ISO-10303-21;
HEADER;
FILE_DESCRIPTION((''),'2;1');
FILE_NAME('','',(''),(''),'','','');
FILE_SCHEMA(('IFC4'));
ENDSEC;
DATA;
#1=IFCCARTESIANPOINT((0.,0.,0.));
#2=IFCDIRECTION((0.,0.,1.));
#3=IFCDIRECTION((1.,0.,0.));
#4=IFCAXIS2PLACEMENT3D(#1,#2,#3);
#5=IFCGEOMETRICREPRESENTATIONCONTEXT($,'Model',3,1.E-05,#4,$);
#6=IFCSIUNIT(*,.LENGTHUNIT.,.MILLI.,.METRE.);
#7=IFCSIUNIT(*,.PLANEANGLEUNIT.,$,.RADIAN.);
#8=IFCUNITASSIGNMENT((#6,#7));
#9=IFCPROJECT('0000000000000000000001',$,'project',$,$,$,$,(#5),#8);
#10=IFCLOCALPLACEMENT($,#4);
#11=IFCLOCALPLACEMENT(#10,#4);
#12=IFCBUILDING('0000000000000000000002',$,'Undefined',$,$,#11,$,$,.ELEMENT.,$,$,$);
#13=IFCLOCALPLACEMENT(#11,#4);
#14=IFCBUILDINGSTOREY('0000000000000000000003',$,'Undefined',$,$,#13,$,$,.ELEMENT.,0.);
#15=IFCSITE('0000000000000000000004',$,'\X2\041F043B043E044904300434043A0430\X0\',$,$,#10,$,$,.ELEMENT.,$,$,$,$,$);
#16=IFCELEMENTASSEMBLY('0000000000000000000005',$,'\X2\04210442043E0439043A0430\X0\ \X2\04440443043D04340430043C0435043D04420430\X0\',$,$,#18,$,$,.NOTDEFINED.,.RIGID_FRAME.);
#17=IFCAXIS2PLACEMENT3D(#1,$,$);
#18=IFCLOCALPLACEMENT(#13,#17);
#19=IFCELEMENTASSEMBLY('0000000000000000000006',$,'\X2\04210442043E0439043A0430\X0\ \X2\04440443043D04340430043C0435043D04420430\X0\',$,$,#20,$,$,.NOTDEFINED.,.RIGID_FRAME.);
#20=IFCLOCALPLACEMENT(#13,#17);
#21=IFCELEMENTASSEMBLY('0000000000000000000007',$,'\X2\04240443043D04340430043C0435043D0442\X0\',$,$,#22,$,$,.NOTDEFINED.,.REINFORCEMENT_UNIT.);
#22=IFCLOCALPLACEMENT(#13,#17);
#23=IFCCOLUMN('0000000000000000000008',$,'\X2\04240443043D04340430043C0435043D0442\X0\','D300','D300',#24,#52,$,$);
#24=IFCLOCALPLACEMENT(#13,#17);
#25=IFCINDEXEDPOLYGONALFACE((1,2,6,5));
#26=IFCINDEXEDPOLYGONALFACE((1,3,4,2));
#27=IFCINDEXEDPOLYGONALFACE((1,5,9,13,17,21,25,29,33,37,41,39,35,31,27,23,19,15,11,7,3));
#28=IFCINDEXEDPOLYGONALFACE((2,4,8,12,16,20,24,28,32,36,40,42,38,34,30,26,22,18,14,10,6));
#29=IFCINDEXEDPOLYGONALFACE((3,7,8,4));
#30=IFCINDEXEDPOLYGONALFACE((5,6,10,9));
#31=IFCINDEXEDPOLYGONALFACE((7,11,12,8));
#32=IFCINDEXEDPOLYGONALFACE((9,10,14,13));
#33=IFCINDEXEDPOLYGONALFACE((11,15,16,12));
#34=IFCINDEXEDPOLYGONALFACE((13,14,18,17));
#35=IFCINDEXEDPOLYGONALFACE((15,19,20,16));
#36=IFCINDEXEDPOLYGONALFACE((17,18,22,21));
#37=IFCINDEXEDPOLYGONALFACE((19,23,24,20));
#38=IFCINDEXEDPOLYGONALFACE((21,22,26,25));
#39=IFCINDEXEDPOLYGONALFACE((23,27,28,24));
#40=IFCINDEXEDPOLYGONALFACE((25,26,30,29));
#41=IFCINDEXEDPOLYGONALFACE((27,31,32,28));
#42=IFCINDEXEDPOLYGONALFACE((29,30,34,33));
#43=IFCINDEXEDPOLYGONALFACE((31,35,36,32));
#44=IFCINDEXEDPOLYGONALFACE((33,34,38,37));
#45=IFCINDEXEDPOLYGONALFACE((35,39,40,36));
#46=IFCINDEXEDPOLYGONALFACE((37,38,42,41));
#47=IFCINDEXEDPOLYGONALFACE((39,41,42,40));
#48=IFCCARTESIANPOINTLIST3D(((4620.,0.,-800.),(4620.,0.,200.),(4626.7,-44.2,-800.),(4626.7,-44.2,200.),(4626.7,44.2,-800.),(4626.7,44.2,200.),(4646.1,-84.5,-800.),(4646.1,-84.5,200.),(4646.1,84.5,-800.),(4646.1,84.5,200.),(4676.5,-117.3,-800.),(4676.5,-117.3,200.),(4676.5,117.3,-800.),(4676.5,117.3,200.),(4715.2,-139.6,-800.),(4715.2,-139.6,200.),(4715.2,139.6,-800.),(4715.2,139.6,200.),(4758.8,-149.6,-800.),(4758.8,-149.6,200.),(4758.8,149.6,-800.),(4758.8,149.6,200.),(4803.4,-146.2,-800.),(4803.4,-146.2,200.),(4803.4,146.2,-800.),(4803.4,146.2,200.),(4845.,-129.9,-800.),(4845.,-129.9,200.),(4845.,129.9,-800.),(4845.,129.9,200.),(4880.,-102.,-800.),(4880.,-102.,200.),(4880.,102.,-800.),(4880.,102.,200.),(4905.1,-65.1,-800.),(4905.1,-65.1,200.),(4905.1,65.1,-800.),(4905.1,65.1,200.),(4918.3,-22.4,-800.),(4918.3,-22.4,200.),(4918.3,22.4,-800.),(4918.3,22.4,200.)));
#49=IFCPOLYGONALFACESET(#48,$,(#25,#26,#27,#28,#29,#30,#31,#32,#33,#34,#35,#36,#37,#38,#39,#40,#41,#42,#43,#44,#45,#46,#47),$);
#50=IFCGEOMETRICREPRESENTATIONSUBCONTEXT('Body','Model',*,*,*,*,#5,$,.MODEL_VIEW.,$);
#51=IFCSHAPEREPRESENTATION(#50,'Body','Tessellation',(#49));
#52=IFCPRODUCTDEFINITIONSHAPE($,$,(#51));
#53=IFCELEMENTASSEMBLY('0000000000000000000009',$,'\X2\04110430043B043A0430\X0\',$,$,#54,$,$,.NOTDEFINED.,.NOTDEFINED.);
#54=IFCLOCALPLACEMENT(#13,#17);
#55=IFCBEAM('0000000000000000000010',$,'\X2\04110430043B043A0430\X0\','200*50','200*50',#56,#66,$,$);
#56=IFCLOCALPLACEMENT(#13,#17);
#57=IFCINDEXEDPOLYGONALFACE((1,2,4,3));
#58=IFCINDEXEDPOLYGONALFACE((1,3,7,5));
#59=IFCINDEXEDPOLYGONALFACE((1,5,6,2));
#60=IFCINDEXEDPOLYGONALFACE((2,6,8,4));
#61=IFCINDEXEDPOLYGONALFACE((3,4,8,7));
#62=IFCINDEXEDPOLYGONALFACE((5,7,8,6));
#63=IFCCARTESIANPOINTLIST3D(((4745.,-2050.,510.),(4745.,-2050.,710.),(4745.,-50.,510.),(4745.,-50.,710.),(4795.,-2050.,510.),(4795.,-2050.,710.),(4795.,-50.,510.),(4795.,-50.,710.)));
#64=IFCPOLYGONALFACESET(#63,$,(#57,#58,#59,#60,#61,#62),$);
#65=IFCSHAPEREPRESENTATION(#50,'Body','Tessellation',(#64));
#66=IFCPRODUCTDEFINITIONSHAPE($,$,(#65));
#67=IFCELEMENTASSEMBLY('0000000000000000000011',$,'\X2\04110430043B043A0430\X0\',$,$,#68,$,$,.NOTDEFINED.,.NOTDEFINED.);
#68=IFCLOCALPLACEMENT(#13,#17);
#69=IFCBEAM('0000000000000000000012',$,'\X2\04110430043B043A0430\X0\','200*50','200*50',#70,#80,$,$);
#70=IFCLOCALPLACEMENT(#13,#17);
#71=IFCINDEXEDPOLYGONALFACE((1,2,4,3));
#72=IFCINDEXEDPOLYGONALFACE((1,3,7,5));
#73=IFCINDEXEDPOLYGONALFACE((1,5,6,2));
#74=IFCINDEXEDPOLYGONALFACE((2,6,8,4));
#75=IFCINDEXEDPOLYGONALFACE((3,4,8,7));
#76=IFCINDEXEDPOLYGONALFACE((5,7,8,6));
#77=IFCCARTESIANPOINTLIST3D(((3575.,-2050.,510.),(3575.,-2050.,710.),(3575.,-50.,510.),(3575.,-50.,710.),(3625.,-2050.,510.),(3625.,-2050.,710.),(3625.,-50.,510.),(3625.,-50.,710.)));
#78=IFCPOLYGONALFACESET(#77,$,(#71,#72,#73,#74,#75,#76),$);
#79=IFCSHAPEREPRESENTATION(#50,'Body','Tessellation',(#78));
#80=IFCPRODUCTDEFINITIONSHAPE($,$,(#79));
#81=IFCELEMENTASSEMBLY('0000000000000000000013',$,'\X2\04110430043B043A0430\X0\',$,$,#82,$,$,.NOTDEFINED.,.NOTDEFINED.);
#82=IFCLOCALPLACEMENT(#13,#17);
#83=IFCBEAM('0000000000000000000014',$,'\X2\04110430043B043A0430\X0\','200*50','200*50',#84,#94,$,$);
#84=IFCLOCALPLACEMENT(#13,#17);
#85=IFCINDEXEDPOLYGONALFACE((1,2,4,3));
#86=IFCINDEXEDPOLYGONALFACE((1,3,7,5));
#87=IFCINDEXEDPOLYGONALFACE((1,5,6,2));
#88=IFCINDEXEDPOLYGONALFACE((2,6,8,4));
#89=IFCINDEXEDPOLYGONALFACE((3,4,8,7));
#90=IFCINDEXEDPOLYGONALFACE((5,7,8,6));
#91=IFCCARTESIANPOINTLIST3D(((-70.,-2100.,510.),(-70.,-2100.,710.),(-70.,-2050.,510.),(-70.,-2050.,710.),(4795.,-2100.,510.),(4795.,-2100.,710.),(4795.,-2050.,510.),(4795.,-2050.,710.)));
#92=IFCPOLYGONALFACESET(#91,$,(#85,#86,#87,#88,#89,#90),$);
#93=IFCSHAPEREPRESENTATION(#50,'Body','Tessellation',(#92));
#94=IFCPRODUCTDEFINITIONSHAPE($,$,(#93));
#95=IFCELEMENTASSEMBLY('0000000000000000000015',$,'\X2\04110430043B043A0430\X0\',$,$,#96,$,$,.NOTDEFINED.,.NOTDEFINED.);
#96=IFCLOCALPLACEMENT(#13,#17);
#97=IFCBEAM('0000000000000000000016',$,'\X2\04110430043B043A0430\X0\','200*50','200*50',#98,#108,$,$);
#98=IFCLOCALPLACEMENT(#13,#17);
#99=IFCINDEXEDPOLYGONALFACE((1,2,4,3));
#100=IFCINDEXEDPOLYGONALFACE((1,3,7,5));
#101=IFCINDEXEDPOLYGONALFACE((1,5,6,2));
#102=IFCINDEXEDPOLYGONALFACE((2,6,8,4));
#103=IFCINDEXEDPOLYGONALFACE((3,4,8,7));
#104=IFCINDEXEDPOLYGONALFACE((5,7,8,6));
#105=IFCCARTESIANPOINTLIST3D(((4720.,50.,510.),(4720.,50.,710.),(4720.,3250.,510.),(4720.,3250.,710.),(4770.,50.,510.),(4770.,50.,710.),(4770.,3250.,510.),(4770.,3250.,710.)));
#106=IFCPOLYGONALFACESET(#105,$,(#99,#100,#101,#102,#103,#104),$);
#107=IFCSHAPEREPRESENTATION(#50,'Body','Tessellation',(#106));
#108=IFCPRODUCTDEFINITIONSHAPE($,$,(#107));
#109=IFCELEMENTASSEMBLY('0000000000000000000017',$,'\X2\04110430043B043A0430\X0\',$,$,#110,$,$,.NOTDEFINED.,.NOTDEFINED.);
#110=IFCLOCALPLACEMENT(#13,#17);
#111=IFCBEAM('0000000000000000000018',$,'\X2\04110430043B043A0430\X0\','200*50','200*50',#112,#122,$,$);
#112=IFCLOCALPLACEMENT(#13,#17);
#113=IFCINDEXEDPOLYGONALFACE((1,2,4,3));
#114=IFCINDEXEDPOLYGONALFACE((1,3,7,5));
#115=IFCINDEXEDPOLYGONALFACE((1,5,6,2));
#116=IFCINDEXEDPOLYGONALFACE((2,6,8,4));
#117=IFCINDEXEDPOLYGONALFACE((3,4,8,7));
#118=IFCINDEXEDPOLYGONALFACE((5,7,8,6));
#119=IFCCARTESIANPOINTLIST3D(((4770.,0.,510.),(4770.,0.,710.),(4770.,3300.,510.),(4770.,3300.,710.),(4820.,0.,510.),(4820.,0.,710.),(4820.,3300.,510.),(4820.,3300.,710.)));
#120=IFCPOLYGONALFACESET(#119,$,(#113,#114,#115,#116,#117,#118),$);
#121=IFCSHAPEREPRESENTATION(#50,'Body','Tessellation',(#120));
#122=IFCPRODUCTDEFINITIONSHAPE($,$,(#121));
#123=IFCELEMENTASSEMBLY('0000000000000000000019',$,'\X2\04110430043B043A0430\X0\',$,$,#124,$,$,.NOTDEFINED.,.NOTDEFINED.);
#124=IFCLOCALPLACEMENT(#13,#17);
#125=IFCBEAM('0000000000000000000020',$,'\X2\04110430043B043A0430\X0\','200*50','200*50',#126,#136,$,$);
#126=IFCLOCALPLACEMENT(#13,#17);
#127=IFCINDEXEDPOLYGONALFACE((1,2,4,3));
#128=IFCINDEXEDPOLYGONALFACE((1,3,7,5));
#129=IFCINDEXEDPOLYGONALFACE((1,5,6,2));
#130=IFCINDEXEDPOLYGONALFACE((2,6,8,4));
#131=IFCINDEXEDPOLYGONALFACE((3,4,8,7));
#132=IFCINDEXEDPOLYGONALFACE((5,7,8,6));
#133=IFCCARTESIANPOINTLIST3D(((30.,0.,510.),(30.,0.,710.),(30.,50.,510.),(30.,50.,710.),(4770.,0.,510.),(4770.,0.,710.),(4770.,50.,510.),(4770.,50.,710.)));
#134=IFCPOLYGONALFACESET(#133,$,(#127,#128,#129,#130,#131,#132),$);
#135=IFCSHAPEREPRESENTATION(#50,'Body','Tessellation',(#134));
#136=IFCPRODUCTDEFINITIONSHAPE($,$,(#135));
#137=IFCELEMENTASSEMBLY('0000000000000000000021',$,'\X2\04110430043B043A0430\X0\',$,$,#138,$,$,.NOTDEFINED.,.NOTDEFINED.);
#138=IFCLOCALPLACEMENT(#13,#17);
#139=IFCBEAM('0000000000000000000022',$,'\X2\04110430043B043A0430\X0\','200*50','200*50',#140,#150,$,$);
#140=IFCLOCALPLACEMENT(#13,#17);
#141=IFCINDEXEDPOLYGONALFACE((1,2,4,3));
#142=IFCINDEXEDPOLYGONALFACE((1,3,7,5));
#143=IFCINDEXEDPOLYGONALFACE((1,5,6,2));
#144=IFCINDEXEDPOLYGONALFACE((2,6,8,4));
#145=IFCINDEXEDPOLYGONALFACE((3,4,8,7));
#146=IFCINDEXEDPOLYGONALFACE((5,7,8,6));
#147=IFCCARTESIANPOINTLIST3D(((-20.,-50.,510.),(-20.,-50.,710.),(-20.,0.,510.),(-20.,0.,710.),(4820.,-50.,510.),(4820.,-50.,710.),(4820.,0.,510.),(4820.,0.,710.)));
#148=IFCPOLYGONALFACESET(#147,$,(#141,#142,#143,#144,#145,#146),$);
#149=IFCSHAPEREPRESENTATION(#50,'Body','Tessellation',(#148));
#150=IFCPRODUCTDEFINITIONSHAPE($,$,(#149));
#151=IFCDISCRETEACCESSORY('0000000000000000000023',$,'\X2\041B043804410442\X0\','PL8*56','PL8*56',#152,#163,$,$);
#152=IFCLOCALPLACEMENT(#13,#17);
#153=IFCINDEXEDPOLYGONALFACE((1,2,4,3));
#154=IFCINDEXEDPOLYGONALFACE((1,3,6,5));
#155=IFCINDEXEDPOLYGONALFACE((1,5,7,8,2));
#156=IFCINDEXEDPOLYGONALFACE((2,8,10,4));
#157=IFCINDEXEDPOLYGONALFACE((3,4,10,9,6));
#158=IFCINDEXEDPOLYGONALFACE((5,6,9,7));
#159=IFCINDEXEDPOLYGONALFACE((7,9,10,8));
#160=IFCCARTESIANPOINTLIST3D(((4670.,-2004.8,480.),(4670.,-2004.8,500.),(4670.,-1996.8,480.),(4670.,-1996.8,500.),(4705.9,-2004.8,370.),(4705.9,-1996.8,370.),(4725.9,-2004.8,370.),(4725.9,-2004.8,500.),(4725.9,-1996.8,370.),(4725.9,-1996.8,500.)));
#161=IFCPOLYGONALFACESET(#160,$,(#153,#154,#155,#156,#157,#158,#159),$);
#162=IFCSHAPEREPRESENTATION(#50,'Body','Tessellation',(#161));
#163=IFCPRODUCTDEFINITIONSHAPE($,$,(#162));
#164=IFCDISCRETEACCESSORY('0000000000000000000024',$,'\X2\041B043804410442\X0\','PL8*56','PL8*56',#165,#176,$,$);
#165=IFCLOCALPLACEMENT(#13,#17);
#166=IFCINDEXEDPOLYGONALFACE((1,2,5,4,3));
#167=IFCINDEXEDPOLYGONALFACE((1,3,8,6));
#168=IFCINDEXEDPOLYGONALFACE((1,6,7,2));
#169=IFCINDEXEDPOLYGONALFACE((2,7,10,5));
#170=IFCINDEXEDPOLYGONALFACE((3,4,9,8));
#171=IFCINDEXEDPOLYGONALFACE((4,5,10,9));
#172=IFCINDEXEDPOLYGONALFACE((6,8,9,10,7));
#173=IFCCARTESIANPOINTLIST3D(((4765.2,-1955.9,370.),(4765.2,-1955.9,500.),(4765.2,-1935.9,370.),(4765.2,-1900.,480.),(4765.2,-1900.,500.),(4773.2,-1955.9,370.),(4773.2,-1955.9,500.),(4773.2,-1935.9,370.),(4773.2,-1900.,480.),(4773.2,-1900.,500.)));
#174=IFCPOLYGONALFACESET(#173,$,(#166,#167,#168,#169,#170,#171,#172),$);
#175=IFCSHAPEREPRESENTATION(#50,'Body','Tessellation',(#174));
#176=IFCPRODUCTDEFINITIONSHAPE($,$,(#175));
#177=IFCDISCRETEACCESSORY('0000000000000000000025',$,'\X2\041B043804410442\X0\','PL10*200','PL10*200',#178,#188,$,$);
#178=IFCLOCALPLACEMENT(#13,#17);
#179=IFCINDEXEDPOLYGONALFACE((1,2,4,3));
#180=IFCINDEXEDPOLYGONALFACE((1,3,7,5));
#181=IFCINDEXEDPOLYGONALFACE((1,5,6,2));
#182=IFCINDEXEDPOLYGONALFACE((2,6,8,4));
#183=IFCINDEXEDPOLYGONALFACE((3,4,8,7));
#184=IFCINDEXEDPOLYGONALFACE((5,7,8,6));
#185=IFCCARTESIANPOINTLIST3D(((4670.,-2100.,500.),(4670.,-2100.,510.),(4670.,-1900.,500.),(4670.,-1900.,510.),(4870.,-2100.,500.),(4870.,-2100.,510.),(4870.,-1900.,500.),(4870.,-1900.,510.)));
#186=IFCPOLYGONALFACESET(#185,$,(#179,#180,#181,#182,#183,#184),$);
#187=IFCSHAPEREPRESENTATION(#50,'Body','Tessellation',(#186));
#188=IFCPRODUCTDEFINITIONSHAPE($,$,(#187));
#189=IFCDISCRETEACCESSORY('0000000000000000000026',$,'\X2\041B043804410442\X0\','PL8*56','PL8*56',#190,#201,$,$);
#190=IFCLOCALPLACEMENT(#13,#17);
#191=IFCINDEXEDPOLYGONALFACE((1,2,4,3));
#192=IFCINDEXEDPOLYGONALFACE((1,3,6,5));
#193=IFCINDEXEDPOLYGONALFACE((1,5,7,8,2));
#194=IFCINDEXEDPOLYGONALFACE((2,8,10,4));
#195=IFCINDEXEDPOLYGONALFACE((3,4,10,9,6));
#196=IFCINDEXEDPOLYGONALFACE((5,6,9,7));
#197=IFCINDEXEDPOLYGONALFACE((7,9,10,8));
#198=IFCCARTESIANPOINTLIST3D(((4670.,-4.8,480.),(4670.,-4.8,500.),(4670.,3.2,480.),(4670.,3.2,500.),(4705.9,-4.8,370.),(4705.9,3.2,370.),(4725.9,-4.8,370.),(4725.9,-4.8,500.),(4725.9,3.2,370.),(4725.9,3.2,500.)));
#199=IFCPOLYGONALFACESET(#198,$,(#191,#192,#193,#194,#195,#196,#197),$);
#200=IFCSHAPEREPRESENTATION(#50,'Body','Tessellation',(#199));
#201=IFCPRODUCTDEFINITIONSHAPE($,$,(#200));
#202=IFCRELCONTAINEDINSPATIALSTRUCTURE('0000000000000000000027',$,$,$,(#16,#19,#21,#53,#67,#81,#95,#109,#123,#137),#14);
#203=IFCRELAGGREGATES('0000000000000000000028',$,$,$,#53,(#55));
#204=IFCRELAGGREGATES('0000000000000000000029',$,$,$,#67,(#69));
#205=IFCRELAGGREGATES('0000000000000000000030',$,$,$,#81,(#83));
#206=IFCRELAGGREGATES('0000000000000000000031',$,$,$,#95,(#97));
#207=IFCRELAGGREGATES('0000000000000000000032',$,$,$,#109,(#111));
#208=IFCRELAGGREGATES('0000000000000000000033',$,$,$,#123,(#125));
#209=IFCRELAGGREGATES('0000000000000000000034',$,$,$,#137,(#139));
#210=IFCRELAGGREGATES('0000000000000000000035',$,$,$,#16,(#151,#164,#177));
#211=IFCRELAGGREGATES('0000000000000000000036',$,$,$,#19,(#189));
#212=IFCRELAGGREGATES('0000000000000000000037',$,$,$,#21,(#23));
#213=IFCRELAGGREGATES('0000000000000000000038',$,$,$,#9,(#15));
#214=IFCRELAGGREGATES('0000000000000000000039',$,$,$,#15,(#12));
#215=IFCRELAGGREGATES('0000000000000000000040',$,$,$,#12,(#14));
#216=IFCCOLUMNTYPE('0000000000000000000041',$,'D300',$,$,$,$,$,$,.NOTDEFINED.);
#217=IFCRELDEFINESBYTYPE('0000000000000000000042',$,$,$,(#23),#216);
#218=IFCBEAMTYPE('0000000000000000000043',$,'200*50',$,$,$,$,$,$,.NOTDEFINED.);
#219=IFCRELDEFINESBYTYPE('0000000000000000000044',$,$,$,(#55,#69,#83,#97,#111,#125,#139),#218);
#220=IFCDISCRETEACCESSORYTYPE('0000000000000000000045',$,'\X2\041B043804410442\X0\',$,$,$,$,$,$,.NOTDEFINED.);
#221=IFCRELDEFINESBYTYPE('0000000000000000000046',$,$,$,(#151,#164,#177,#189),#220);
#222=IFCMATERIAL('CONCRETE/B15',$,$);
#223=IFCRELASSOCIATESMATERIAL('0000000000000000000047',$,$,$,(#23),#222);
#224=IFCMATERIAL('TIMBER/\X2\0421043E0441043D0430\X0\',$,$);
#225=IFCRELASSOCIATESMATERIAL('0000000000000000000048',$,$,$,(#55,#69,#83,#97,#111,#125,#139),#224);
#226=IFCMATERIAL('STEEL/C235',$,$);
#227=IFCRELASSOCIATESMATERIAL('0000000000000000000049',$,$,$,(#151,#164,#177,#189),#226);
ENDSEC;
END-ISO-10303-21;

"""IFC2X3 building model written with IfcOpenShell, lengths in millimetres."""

from ifc_helpers import new_model, si_unit, frame, origin_with_axes, origin_2d_with_axis, place, context, subcontext, project, spatial, polyline, rectangle, circle, outline, extrude, material, type_object, element, aggregate, save


model = new_model("IFC2X3")

# Units and contexts
model_context = context("Model", 3, precision=1e-05, world=origin_with_axes())
body_context = subcontext(model_context, "Body", "Model", "MODEL_VIEW")
ifc_project = project(units=[si_unit("LENGTHUNIT", "METRE", prefix="MILLI"), si_unit("PLANEANGLEUNIT", "RADIAN")], contexts=[model_context])

# Site, building, storey
site_placement = place(None, origin_with_axes())
site = spatial("IfcSite", under=ifc_project, at=site_placement, Name="Площадка", CompositionType="ELEMENT")
building_placement = place(site_placement, origin_with_axes())
building = spatial("IfcBuilding", under=site, at=building_placement, Name="Undefined", CompositionType="ELEMENT")
storey_placement = place(building_placement, origin_with_axes())
storey = spatial("IfcBuildingStorey", under=building, at=storey_placement, Name="Undefined", CompositionType="ELEMENT", Elevation=0.0)

# Element assemblies, column
assembly_1_placement = place(storey_placement, origin_with_axes())
assembly_1 = element("IfcElementAssembly", 1, at=assembly_1_placement, inside=storey, Name="Стойка фундамента", AssemblyPlace="NOTDEFINED", PredefinedType="RIGID_FRAME")
ifc_material_1 = material(Name="STEEL/C235")
assembly_2_placement = place(storey_placement, origin_with_axes())
assembly_2 = element("IfcElementAssembly", 2, at=assembly_2_placement, inside=storey, Name="Стойка фундамента", AssemblyPlace="NOTDEFINED", PredefinedType="RIGID_FRAME")
ifc_material_2 = material(Name="CONCRETE/B15")
column_type_1 = type_object("IfcColumnType", Name="D300", PredefinedType="NOTDEFINED")
assembly_3_placement = place(storey_placement, origin_with_axes())
assembly_3 = element("IfcElementAssembly", 3, at=assembly_3_placement, inside=storey, Name="Фундамент", AssemblyPlace="NOTDEFINED", PredefinedType="REINFORCEMENT_UNIT")
column_1_placement = place(assembly_3_placement, frame((4770.0, 0.0, -800.0), z_axis=(0.0, 0.0, 1.0), x_axis=(0.0, 1.0, 0.0)))
column_1 = element("IfcColumn", 4, at=column_1_placement, type_object=column_type_1, material=ifc_material_2, Name="Фундамент", Description="D300", ObjectType="D300", context=body_context, shape_type="SweptSolid", body=[
    extrude(circle(Radius=150.0, at=origin_2d_with_axis()), frame((0.0, 0.0, 1000.0), z_axis=(0.0, 0.0, -1.0), x_axis=(0.0, 1.0, 0.0)), (0.0, 0.0, 1.0), 1000.0),
])

# Element assemblies, beams
assembly_4_placement = place(storey_placement, origin_with_axes())
assembly_4 = element("IfcElementAssembly", 5, at=assembly_4_placement, inside=storey, Name="Балка", AssemblyPlace="NOTDEFINED", PredefinedType="NOTDEFINED")
ifc_material_3 = material(Name="TIMBER/Сосна")
beam_type = type_object("IfcBeamType", Name="200*50", PredefinedType="NOTDEFINED")
beam_1_placement = place(assembly_4_placement, frame((4770.0, -2050.0, 610.0), z_axis=(0.0, 0.0, -1.0), x_axis=(0.0, 1.0, 0.0)))
beam_1 = element("IfcBeam", 6, at=beam_1_placement, type_object=beam_type, material=ifc_material_3, Name="Балка", Description="200*50", ObjectType="200*50", context=body_context, shape_type="SweptSolid", body=[
    extrude(rectangle(XDim=50.0, YDim=200.0, at=origin_2d_with_axis()), frame((2000.0, 0.0, 0.0), z_axis=(-1.0, 0.0, 0.0), x_axis=(0.0, -1.0, 0.0)), (0.0, 0.0, 1.0), 2000.0),
])
aggregate(assembly_4, [beam_1])
assembly_5_placement = place(storey_placement, origin_with_axes())
assembly_5 = element("IfcElementAssembly", 7, at=assembly_5_placement, inside=storey, Name="Балка", AssemblyPlace="NOTDEFINED", PredefinedType="NOTDEFINED")
beam_2_placement = place(assembly_5_placement, frame((3600.0, -2050.0, 610.0), z_axis=(0.0, 0.0, -1.0), x_axis=(0.0, 1.0, 0.0)))
beam_2 = element("IfcBeam", 8, at=beam_2_placement, type_object=beam_type, material=ifc_material_3, Name="Балка", Description="200*50", ObjectType="200*50", context=body_context, shape_type="SweptSolid", body=[
    extrude(rectangle(XDim=50.0, YDim=200.0, at=origin_2d_with_axis()), frame((2000.0, 0.0, 0.0), z_axis=(-1.0, 0.0, 0.0), x_axis=(0.0, -1.0, 0.0)), (0.0, 0.0, 1.0), 2000.0),
])
aggregate(assembly_5, [beam_2])
assembly_6_placement = place(storey_placement, origin_with_axes())
assembly_6 = element("IfcElementAssembly", 9, at=assembly_6_placement, inside=storey, Name="Балка", AssemblyPlace="NOTDEFINED", PredefinedType="NOTDEFINED")
beam_3_placement = place(assembly_6_placement, frame((4795.0, -2075.0, 610.0), z_axis=(0.0, 0.0, -1.0), x_axis=(-1.0, 0.0, 0.0)))
beam_3 = element("IfcBeam", 10, at=beam_3_placement, type_object=beam_type, material=ifc_material_3, Name="Балка", Description="200*50", ObjectType="200*50", context=body_context, shape_type="SweptSolid", body=[
    extrude(rectangle(XDim=50.0, YDim=200.0, at=origin_2d_with_axis()), frame((4865.0, 0.0, 0.0), z_axis=(-1.0, 0.0, 0.0), x_axis=(0.0, -1.0, 0.0)), (0.0, 0.0, 1.0), 4865.0),
])
aggregate(assembly_6, [beam_3])
assembly_7_placement = place(storey_placement, origin_with_axes())
assembly_7 = element("IfcElementAssembly", 11, at=assembly_7_placement, inside=storey, Name="Балка", AssemblyPlace="NOTDEFINED", PredefinedType="NOTDEFINED")
beam_4_placement = place(assembly_7_placement, frame((4745.0, 50.0, 610.0), z_axis=(0.0, 0.0, -1.0), x_axis=(0.0, 1.0, 0.0)))
beam_4 = element("IfcBeam", 12, at=beam_4_placement, type_object=beam_type, material=ifc_material_3, Name="Балка", Description="200*50", ObjectType="200*50", context=body_context, shape_type="SweptSolid", body=[
    extrude(rectangle(XDim=50.0, YDim=200.0, at=origin_2d_with_axis()), frame((3200.0, 0.0, 0.0), z_axis=(-1.0, 0.0, 0.0), x_axis=(0.0, -1.0, 0.0)), (0.0, 0.0, 1.0), 3200.0),
])
aggregate(assembly_7, [beam_4])
assembly_8_placement = place(storey_placement, origin_with_axes())
assembly_8 = element("IfcElementAssembly", 13, at=assembly_8_placement, inside=storey, Name="Балка", AssemblyPlace="NOTDEFINED", PredefinedType="NOTDEFINED")
beam_5_placement = place(assembly_8_placement, frame((4795.0, 0.0, 610.0), z_axis=(0.0, 0.0, -1.0), x_axis=(0.0, 1.0, 0.0)))
beam_5 = element("IfcBeam", 14, at=beam_5_placement, type_object=beam_type, material=ifc_material_3, Name="Балка", Description="200*50", ObjectType="200*50", context=body_context, shape_type="SweptSolid", body=[
    extrude(rectangle(XDim=50.0, YDim=200.0, at=origin_2d_with_axis()), frame((3300.0, 0.0, 0.0), z_axis=(-1.0, 0.0, 0.0), x_axis=(0.0, -1.0, 0.0)), (0.0, 0.0, 1.0), 3300.0),
])
aggregate(assembly_8, [beam_5])
assembly_9_placement = place(storey_placement, origin_with_axes())
assembly_9 = element("IfcElementAssembly", 15, at=assembly_9_placement, inside=storey, Name="Балка", AssemblyPlace="NOTDEFINED", PredefinedType="NOTDEFINED")
beam_6_placement = place(assembly_9_placement, frame((4770.0, 25.0, 610.0), z_axis=(0.0, 0.0, -1.0), x_axis=(-1.0, 0.0, 0.0)))
beam_6 = element("IfcBeam", 16, at=beam_6_placement, type_object=beam_type, material=ifc_material_3, Name="Балка", Description="200*50", ObjectType="200*50", context=body_context, shape_type="SweptSolid", body=[
    extrude(rectangle(XDim=50.0, YDim=200.0, at=origin_2d_with_axis()), frame((4740.0, 0.0, 0.0), z_axis=(-1.0, 0.0, 0.0), x_axis=(0.0, -1.0, 0.0)), (0.0, 0.0, 1.0), 4740.0),
])
aggregate(assembly_9, [beam_6])
assembly_10_placement = place(storey_placement, origin_with_axes())
assembly_10 = element("IfcElementAssembly", 17, at=assembly_10_placement, inside=storey, Name="Балка", AssemblyPlace="NOTDEFINED", PredefinedType="NOTDEFINED")
beam_7_placement = place(assembly_10_placement, frame((4820.0, -25.0, 610.0), z_axis=(0.0, 0.0, -1.0), x_axis=(-1.0, 0.0, 0.0)))
beam_7 = element("IfcBeam", 18, at=beam_7_placement, type_object=beam_type, material=ifc_material_3, Name="Балка", Description="200*50", ObjectType="200*50", context=body_context, shape_type="SweptSolid", body=[
    extrude(rectangle(XDim=50.0, YDim=200.0, at=origin_2d_with_axis()), frame((4840.0, 0.0, 0.0), z_axis=(-1.0, 0.0, 0.0), x_axis=(0.0, -1.0, 0.0)), (0.0, 0.0, 1.0), 4840.0),
])
aggregate(assembly_10, [beam_7])

# Discrete accessories
discrete_accessory_type = type_object("IfcDiscreteAccessoryType", Name="Лист")
discrete_accessory_1_placement = place(assembly_1_placement, frame((4725.9, -2000.8, 500.0), z_axis=(0.0, -1.0, 0.0), x_axis=(-1.0, 0.0, 0.0)))
discrete_accessory_1 = element("IfcDiscreteAccessory", 19, at=discrete_accessory_1_placement, type_object=discrete_accessory_type, material=ifc_material_1, Name="Лист", Description="PL8*56", ObjectType="PL8*56", context=body_context, shape_type="SweptSolid", body=[
    extrude(outline(polyline([(0.0, 0.0), (55.9, 0.0), (55.9, 20.0), (20.0, 130.0), (0.0, 130.0), (0.0, 0.0)])), frame((0.0, 0.0, -4.0), z_axis=(0.0, 0.0, 1.0), x_axis=(1.0, 0.0, 0.0)), (0.0, 0.0, 1.0), 8.0),
])
discrete_accessory_2_placement = place(assembly_1_placement, frame((4769.2, -1955.9, 500.0), z_axis=(-1.0, 0.0, 0.0), x_axis=(0.0, 1.0, 0.0)))
discrete_accessory_2 = element("IfcDiscreteAccessory", 20, at=discrete_accessory_2_placement, type_object=discrete_accessory_type, material=ifc_material_1, Name="Лист", Description="PL8*56", ObjectType="PL8*56", context=body_context, shape_type="SweptSolid", body=[
    extrude(outline(polyline([(0.0, 0.0), (55.9, 0.0), (55.9, 20.0), (20.0, 130.0), (0.0, 130.0), (0.0, 0.0)])), frame((0.0, 0.0, -4.0), z_axis=(0.0, 0.0, 1.0), x_axis=(1.0, 0.0, 0.0)), (0.0, 0.0, 1.0), 8.0),
])
discrete_accessory_3_placement = place(assembly_1_placement, frame((4670.0, -2100.0, 505.0), z_axis=(0.0, 0.0, 1.0), x_axis=(1.0, 0.0, 0.0)))
discrete_accessory_3 = element("IfcDiscreteAccessory", 21, at=discrete_accessory_3_placement, type_object=discrete_accessory_type, material=ifc_material_1, Name="Лист", Description="PL10*200", ObjectType="PL10*200", context=body_context, shape_type="SweptSolid", body=[
    extrude(outline(polyline([(0.0, 0.0), (200.0, 0.0), (200.0, 200.0), (0.0, 200.0), (0.0, 0.0)])), frame((0.0, 0.0, -5.0), z_axis=(0.0, 0.0, 1.0), x_axis=(1.0, 0.0, 0.0)), (0.0, 0.0, 1.0), 10.0),
])
aggregate(assembly_1, [discrete_accessory_1, discrete_accessory_2, discrete_accessory_3])
discrete_accessory_4_placement = place(assembly_2_placement, frame((4725.9, -0.8, 500.0), z_axis=(0.0, -1.0, 0.0), x_axis=(-1.0, 0.0, 0.0)))
discrete_accessory_4 = element("IfcDiscreteAccessory", 22, at=discrete_accessory_4_placement, type_object=discrete_accessory_type, material=ifc_material_1, Name="Лист", Description="PL8*56", ObjectType="PL8*56", context=body_context, shape_type="SweptSolid", body=[
    extrude(outline(polyline([(0.0, 0.0), (55.9, 0.0), (55.9, 20.0), (20.0, 130.0), (0.0, 130.0), (0.0, 0.0)])), frame((0.0, 0.0, -4.0), z_axis=(0.0, 0.0, 1.0), x_axis=(1.0, 0.0, 0.0)), (0.0, 0.0, 1.0), 8.0),
])
aggregate(assembly_2, [discrete_accessory_4])

aggregate(assembly_3, [column_1])

save(model, "model.ifc")
